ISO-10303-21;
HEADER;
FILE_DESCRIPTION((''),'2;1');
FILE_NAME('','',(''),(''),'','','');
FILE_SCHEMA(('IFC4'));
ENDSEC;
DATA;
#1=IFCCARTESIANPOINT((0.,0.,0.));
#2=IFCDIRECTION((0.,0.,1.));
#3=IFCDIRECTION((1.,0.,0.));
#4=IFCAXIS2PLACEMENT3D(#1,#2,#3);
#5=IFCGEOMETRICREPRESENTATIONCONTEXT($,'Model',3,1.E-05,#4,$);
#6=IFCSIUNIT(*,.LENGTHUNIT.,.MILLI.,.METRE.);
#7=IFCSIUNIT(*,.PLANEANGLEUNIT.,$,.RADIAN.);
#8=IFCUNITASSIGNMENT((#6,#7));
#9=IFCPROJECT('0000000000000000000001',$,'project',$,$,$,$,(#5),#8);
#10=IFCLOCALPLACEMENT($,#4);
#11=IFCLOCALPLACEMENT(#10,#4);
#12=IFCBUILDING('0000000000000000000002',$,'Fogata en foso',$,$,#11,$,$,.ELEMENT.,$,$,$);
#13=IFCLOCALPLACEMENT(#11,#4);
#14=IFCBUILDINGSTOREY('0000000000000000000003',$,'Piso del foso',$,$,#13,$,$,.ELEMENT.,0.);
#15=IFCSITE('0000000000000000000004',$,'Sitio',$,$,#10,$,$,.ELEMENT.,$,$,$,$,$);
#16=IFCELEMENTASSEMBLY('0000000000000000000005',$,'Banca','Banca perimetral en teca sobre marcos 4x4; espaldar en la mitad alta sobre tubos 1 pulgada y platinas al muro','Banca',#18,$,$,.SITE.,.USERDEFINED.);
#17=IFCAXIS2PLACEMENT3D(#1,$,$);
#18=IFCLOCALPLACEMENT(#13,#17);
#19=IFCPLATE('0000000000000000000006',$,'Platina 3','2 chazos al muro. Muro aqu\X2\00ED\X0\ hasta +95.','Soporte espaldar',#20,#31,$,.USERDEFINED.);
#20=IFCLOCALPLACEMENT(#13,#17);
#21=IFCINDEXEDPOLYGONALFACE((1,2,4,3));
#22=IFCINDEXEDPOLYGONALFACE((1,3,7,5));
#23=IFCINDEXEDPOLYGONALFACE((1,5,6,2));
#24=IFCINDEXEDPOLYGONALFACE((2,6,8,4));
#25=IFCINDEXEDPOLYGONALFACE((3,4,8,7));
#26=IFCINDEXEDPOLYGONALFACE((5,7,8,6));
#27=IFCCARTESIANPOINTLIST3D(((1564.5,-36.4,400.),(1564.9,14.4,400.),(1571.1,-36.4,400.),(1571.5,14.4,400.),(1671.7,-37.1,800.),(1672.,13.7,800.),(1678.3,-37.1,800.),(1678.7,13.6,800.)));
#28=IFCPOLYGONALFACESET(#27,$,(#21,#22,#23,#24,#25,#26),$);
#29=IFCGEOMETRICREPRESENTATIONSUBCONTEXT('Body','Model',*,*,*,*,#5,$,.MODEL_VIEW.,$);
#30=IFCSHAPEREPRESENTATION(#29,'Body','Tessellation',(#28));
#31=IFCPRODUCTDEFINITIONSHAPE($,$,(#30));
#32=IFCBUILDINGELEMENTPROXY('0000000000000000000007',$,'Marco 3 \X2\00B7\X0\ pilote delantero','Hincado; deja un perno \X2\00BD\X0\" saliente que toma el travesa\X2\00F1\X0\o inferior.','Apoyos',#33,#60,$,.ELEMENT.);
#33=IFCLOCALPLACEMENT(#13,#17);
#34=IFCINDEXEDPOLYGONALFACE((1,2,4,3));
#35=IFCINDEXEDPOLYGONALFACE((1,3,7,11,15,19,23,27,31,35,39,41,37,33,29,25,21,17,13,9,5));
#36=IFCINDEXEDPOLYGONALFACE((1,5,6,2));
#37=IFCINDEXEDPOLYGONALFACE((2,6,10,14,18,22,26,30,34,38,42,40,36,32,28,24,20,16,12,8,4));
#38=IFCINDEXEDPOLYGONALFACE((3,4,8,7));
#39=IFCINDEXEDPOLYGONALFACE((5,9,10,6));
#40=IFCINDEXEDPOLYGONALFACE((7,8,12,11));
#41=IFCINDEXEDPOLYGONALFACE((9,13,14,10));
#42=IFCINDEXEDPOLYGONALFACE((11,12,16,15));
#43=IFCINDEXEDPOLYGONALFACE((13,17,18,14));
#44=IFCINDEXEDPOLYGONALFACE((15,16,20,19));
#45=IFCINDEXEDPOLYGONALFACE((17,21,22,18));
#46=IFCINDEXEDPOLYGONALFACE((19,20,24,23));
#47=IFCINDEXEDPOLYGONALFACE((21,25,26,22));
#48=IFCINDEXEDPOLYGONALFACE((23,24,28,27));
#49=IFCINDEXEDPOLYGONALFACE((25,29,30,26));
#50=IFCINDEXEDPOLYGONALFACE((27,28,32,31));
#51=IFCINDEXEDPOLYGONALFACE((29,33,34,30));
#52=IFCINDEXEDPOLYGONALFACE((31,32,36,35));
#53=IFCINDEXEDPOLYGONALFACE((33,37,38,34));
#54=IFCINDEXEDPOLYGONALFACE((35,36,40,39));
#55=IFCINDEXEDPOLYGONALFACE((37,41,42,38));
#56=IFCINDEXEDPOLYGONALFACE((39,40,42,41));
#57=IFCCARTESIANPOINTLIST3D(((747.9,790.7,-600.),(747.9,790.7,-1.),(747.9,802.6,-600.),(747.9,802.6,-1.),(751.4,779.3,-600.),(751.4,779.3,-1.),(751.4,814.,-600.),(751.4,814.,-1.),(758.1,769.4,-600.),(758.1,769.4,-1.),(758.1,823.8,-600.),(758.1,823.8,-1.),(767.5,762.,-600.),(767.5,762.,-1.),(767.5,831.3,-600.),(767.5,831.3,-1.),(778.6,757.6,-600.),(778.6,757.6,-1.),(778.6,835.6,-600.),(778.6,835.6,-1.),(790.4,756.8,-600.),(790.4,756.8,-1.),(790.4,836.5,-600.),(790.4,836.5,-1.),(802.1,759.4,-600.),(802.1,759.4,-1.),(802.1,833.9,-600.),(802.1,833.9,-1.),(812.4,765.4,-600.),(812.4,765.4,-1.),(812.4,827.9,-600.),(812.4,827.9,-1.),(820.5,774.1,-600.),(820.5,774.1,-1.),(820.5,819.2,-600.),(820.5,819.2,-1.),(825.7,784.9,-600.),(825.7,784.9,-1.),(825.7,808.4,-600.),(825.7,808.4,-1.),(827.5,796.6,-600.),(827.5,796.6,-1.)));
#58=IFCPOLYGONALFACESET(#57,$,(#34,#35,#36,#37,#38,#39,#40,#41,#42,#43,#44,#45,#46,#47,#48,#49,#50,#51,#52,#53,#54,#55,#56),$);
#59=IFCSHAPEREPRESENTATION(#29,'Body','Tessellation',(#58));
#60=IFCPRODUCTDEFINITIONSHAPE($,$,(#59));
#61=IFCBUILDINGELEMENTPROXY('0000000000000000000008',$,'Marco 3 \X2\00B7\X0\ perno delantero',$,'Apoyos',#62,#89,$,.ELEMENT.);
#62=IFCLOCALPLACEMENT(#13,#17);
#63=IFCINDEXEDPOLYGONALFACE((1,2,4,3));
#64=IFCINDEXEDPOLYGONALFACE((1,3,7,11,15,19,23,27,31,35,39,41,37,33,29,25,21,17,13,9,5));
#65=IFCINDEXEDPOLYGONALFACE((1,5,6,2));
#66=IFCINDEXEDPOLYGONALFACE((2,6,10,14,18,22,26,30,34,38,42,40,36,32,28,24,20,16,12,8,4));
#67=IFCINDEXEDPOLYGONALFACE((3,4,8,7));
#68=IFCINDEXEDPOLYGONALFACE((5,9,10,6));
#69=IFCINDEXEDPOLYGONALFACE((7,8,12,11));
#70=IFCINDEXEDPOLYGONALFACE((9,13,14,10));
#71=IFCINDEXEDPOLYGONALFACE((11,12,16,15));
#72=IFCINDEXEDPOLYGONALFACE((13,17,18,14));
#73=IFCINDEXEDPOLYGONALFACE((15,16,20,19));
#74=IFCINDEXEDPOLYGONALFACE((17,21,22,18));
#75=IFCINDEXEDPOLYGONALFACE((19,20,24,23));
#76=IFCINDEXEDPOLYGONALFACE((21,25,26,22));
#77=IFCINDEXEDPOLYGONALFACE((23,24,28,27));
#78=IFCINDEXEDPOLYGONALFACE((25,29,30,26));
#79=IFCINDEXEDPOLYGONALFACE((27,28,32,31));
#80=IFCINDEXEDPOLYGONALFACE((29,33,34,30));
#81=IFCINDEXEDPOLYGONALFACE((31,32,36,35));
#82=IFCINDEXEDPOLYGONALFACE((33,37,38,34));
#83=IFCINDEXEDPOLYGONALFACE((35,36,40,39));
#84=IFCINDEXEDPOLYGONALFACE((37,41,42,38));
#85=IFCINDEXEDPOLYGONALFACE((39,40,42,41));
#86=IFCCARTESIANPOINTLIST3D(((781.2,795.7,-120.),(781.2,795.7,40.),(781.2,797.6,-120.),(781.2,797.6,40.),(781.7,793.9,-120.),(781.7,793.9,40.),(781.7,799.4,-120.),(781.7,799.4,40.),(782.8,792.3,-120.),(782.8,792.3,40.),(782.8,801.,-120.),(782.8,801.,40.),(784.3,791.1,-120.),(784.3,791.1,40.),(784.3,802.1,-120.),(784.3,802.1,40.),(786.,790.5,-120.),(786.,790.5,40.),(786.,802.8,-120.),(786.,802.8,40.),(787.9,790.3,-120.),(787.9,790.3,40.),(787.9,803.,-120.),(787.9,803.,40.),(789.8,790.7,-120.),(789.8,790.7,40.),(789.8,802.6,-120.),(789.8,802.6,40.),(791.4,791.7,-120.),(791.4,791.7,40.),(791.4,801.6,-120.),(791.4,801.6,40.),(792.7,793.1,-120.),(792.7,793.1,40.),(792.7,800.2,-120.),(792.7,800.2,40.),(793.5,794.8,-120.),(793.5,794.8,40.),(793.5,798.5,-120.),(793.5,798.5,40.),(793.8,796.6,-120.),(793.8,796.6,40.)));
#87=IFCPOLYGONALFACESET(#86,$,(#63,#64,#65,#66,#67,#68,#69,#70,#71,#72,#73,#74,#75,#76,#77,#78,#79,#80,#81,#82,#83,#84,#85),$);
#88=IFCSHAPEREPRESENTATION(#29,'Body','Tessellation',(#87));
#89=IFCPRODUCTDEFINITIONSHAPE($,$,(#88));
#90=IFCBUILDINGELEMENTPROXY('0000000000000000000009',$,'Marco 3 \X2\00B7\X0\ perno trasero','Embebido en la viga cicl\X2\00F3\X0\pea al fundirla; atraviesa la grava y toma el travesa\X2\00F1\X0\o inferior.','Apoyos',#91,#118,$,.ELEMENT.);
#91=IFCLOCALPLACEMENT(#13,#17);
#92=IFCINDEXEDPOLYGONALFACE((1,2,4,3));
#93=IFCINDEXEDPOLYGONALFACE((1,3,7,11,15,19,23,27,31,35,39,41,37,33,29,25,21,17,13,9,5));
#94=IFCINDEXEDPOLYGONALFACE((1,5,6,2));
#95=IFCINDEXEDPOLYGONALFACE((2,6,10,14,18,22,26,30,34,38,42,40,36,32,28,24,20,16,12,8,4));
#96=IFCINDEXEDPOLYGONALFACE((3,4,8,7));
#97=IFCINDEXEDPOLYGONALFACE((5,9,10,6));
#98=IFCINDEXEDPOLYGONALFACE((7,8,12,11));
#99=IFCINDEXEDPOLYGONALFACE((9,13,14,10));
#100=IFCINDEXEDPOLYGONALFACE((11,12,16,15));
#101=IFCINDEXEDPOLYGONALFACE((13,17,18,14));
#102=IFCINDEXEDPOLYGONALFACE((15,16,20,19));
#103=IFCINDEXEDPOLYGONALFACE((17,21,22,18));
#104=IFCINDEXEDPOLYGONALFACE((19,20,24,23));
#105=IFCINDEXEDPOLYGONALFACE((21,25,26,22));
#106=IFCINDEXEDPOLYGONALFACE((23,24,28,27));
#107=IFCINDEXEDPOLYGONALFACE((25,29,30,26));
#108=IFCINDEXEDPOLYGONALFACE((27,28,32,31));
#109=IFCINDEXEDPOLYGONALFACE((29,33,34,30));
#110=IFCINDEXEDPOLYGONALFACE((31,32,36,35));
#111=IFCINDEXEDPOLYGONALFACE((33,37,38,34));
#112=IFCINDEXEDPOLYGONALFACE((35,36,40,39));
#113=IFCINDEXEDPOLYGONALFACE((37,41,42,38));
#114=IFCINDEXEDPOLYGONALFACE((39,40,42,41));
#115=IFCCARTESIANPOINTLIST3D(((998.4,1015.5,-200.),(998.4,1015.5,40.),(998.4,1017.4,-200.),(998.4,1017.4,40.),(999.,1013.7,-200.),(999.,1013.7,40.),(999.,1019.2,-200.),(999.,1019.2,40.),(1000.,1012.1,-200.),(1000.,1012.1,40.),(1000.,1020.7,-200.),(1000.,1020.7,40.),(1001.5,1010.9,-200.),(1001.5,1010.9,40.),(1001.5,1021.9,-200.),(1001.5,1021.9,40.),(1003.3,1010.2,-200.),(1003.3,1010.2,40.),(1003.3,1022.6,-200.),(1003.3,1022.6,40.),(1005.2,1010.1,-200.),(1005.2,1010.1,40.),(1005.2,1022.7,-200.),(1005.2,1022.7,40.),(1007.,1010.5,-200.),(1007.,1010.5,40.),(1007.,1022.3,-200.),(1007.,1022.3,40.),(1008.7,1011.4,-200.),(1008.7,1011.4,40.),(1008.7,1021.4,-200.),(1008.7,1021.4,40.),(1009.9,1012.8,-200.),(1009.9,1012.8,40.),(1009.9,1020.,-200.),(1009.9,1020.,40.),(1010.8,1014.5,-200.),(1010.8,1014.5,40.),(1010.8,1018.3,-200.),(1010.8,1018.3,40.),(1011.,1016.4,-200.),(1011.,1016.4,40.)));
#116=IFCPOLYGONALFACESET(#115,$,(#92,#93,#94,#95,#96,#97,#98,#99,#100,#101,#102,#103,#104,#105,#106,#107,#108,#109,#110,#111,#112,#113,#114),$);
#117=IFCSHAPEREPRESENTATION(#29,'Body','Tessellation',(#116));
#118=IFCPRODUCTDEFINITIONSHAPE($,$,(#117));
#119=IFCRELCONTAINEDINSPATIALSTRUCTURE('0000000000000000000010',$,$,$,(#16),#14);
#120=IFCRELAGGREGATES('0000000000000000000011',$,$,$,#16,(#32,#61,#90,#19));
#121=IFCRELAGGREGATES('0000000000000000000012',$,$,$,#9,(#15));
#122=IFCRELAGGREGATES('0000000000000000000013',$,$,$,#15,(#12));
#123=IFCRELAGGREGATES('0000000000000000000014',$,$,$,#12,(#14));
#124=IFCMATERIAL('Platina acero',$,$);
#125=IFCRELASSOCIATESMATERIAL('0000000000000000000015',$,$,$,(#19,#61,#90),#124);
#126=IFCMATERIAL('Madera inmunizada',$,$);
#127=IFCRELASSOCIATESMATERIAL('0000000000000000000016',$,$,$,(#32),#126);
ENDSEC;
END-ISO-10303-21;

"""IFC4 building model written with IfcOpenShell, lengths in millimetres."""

from ifc_helpers import new_model, si_unit, frame, origin_with_axes, origin_2d, place, context, subcontext, project, spatial, polyline, circle, outline, extrude, material, element, aggregate, save


model = new_model("IFC4")

# Units and contexts
model_context = context("Model", 3, precision=1e-05, world=origin_with_axes())
body_context = subcontext(model_context, "Body", "Model", "MODEL_VIEW")
ifc_project = project(units=[si_unit("LENGTHUNIT", "METRE", prefix="MILLI"), si_unit("PLANEANGLEUNIT", "RADIAN")], contexts=[model_context])

# Site, building, storey
site_placement = place(None, origin_with_axes())
site = spatial("IfcSite", under=ifc_project, at=site_placement, Name="Sitio", CompositionType="ELEMENT")
building_placement = place(site_placement, origin_with_axes())
building = spatial("IfcBuilding", under=site, at=building_placement, Name="Fogata en foso", CompositionType="ELEMENT")
storey_placement = place(building_placement, origin_with_axes())
storey = spatial("IfcBuildingStorey", under=building, at=storey_placement, Name="Piso del foso", CompositionType="ELEMENT", Elevation=0.0)

# Element assembly
assembly_1_placement = place(storey_placement, origin_with_axes())
assembly_1 = element("IfcElementAssembly", 1, at=assembly_1_placement, inside=storey, Name="Banca", Description="Banca perimetral en teca sobre marcos 4x4; espaldar en la mitad alta sobre tubos 1 pulgada y platinas al muro", ObjectType="Banca", AssemblyPlace="SITE", PredefinedType="USERDEFINED")

# Plate
ifc_material_1 = material(Name="Platina acero")
plate_1_placement = place(storey_placement, frame((0.2, 25.4, 0.0), z_axis=(-0.007, -1.0, 0.0), x_axis=(1.0, -0.007, 0.0)))
plate_1 = element("IfcPlate", 2, at=plate_1_placement, material=ifc_material_1, Name="Platina 3", Description="2 chazos al muro. Muro aquí hasta +95.", ObjectType="Soporte espaldar", PredefinedType="USERDEFINED", context=body_context, shape_type="SweptSolid", body=[
    extrude(outline(polyline([(1564.7, 400.0), (1571.3, 400.0), (1678.5, 800.0), (1671.9, 800.0), (1564.7, 400.0)])), origin_with_axes(), (0.0, 0.0, 1.0), 50.8),
])

# Building element proxies
ifc_material_2 = material(Name="Madera inmunizada")
proxy_1_placement = place(storey_placement, frame((787.5, 796.6, -600.0), z_axis=(0.0, 0.0, 1.0), x_axis=(1.0, 0.0, 0.0)))
proxy_1 = element("IfcBuildingElementProxy", 3, at=proxy_1_placement, material=ifc_material_2, Name="Marco 3 · pilote delantero", Description="Hincado; deja un perno ½\" saliente que toma el travesaño inferior.", ObjectType="Apoyos", PredefinedType="ELEMENT", context=body_context, shape_type="SweptSolid", body=[
    extrude(circle(Radius=40.0, at=origin_2d()), origin_with_axes(), (0.0, 0.0, 1.0), 599.0),
])
proxy_2_placement = place(storey_placement, frame((787.5, 796.6, -120.0), z_axis=(0.0, 0.0, 1.0), x_axis=(1.0, 0.0, 0.0)))
proxy_2 = element("IfcBuildingElementProxy", 4, at=proxy_2_placement, material=ifc_material_1, Name="Marco 3 · perno delantero", ObjectType="Apoyos", PredefinedType="ELEMENT", context=body_context, shape_type="SweptSolid", body=[
    extrude(circle(Radius=6.3, at=origin_2d()), origin_with_axes(), (0.0, 0.0, 1.0), 160.0),
])
proxy_3_placement = place(storey_placement, frame((1004.7, 1016.4, -200.0), z_axis=(0.0, 0.0, 1.0), x_axis=(1.0, 0.0, 0.0)))
proxy_3 = element("IfcBuildingElementProxy", 5, at=proxy_3_placement, material=ifc_material_1, Name="Marco 3 · perno trasero", Description="Embebido en la viga ciclópea al fundirla; atraviesa la grava y toma el travesaño inferior.", ObjectType="Apoyos", PredefinedType="ELEMENT", context=body_context, shape_type="SweptSolid", body=[
    extrude(circle(Radius=6.3, at=origin_2d()), origin_with_axes(), (0.0, 0.0, 1.0), 240.0),
])

aggregate(assembly_1, [proxy_1, proxy_2, proxy_3, plate_1])

save(model, "model.ifc")
